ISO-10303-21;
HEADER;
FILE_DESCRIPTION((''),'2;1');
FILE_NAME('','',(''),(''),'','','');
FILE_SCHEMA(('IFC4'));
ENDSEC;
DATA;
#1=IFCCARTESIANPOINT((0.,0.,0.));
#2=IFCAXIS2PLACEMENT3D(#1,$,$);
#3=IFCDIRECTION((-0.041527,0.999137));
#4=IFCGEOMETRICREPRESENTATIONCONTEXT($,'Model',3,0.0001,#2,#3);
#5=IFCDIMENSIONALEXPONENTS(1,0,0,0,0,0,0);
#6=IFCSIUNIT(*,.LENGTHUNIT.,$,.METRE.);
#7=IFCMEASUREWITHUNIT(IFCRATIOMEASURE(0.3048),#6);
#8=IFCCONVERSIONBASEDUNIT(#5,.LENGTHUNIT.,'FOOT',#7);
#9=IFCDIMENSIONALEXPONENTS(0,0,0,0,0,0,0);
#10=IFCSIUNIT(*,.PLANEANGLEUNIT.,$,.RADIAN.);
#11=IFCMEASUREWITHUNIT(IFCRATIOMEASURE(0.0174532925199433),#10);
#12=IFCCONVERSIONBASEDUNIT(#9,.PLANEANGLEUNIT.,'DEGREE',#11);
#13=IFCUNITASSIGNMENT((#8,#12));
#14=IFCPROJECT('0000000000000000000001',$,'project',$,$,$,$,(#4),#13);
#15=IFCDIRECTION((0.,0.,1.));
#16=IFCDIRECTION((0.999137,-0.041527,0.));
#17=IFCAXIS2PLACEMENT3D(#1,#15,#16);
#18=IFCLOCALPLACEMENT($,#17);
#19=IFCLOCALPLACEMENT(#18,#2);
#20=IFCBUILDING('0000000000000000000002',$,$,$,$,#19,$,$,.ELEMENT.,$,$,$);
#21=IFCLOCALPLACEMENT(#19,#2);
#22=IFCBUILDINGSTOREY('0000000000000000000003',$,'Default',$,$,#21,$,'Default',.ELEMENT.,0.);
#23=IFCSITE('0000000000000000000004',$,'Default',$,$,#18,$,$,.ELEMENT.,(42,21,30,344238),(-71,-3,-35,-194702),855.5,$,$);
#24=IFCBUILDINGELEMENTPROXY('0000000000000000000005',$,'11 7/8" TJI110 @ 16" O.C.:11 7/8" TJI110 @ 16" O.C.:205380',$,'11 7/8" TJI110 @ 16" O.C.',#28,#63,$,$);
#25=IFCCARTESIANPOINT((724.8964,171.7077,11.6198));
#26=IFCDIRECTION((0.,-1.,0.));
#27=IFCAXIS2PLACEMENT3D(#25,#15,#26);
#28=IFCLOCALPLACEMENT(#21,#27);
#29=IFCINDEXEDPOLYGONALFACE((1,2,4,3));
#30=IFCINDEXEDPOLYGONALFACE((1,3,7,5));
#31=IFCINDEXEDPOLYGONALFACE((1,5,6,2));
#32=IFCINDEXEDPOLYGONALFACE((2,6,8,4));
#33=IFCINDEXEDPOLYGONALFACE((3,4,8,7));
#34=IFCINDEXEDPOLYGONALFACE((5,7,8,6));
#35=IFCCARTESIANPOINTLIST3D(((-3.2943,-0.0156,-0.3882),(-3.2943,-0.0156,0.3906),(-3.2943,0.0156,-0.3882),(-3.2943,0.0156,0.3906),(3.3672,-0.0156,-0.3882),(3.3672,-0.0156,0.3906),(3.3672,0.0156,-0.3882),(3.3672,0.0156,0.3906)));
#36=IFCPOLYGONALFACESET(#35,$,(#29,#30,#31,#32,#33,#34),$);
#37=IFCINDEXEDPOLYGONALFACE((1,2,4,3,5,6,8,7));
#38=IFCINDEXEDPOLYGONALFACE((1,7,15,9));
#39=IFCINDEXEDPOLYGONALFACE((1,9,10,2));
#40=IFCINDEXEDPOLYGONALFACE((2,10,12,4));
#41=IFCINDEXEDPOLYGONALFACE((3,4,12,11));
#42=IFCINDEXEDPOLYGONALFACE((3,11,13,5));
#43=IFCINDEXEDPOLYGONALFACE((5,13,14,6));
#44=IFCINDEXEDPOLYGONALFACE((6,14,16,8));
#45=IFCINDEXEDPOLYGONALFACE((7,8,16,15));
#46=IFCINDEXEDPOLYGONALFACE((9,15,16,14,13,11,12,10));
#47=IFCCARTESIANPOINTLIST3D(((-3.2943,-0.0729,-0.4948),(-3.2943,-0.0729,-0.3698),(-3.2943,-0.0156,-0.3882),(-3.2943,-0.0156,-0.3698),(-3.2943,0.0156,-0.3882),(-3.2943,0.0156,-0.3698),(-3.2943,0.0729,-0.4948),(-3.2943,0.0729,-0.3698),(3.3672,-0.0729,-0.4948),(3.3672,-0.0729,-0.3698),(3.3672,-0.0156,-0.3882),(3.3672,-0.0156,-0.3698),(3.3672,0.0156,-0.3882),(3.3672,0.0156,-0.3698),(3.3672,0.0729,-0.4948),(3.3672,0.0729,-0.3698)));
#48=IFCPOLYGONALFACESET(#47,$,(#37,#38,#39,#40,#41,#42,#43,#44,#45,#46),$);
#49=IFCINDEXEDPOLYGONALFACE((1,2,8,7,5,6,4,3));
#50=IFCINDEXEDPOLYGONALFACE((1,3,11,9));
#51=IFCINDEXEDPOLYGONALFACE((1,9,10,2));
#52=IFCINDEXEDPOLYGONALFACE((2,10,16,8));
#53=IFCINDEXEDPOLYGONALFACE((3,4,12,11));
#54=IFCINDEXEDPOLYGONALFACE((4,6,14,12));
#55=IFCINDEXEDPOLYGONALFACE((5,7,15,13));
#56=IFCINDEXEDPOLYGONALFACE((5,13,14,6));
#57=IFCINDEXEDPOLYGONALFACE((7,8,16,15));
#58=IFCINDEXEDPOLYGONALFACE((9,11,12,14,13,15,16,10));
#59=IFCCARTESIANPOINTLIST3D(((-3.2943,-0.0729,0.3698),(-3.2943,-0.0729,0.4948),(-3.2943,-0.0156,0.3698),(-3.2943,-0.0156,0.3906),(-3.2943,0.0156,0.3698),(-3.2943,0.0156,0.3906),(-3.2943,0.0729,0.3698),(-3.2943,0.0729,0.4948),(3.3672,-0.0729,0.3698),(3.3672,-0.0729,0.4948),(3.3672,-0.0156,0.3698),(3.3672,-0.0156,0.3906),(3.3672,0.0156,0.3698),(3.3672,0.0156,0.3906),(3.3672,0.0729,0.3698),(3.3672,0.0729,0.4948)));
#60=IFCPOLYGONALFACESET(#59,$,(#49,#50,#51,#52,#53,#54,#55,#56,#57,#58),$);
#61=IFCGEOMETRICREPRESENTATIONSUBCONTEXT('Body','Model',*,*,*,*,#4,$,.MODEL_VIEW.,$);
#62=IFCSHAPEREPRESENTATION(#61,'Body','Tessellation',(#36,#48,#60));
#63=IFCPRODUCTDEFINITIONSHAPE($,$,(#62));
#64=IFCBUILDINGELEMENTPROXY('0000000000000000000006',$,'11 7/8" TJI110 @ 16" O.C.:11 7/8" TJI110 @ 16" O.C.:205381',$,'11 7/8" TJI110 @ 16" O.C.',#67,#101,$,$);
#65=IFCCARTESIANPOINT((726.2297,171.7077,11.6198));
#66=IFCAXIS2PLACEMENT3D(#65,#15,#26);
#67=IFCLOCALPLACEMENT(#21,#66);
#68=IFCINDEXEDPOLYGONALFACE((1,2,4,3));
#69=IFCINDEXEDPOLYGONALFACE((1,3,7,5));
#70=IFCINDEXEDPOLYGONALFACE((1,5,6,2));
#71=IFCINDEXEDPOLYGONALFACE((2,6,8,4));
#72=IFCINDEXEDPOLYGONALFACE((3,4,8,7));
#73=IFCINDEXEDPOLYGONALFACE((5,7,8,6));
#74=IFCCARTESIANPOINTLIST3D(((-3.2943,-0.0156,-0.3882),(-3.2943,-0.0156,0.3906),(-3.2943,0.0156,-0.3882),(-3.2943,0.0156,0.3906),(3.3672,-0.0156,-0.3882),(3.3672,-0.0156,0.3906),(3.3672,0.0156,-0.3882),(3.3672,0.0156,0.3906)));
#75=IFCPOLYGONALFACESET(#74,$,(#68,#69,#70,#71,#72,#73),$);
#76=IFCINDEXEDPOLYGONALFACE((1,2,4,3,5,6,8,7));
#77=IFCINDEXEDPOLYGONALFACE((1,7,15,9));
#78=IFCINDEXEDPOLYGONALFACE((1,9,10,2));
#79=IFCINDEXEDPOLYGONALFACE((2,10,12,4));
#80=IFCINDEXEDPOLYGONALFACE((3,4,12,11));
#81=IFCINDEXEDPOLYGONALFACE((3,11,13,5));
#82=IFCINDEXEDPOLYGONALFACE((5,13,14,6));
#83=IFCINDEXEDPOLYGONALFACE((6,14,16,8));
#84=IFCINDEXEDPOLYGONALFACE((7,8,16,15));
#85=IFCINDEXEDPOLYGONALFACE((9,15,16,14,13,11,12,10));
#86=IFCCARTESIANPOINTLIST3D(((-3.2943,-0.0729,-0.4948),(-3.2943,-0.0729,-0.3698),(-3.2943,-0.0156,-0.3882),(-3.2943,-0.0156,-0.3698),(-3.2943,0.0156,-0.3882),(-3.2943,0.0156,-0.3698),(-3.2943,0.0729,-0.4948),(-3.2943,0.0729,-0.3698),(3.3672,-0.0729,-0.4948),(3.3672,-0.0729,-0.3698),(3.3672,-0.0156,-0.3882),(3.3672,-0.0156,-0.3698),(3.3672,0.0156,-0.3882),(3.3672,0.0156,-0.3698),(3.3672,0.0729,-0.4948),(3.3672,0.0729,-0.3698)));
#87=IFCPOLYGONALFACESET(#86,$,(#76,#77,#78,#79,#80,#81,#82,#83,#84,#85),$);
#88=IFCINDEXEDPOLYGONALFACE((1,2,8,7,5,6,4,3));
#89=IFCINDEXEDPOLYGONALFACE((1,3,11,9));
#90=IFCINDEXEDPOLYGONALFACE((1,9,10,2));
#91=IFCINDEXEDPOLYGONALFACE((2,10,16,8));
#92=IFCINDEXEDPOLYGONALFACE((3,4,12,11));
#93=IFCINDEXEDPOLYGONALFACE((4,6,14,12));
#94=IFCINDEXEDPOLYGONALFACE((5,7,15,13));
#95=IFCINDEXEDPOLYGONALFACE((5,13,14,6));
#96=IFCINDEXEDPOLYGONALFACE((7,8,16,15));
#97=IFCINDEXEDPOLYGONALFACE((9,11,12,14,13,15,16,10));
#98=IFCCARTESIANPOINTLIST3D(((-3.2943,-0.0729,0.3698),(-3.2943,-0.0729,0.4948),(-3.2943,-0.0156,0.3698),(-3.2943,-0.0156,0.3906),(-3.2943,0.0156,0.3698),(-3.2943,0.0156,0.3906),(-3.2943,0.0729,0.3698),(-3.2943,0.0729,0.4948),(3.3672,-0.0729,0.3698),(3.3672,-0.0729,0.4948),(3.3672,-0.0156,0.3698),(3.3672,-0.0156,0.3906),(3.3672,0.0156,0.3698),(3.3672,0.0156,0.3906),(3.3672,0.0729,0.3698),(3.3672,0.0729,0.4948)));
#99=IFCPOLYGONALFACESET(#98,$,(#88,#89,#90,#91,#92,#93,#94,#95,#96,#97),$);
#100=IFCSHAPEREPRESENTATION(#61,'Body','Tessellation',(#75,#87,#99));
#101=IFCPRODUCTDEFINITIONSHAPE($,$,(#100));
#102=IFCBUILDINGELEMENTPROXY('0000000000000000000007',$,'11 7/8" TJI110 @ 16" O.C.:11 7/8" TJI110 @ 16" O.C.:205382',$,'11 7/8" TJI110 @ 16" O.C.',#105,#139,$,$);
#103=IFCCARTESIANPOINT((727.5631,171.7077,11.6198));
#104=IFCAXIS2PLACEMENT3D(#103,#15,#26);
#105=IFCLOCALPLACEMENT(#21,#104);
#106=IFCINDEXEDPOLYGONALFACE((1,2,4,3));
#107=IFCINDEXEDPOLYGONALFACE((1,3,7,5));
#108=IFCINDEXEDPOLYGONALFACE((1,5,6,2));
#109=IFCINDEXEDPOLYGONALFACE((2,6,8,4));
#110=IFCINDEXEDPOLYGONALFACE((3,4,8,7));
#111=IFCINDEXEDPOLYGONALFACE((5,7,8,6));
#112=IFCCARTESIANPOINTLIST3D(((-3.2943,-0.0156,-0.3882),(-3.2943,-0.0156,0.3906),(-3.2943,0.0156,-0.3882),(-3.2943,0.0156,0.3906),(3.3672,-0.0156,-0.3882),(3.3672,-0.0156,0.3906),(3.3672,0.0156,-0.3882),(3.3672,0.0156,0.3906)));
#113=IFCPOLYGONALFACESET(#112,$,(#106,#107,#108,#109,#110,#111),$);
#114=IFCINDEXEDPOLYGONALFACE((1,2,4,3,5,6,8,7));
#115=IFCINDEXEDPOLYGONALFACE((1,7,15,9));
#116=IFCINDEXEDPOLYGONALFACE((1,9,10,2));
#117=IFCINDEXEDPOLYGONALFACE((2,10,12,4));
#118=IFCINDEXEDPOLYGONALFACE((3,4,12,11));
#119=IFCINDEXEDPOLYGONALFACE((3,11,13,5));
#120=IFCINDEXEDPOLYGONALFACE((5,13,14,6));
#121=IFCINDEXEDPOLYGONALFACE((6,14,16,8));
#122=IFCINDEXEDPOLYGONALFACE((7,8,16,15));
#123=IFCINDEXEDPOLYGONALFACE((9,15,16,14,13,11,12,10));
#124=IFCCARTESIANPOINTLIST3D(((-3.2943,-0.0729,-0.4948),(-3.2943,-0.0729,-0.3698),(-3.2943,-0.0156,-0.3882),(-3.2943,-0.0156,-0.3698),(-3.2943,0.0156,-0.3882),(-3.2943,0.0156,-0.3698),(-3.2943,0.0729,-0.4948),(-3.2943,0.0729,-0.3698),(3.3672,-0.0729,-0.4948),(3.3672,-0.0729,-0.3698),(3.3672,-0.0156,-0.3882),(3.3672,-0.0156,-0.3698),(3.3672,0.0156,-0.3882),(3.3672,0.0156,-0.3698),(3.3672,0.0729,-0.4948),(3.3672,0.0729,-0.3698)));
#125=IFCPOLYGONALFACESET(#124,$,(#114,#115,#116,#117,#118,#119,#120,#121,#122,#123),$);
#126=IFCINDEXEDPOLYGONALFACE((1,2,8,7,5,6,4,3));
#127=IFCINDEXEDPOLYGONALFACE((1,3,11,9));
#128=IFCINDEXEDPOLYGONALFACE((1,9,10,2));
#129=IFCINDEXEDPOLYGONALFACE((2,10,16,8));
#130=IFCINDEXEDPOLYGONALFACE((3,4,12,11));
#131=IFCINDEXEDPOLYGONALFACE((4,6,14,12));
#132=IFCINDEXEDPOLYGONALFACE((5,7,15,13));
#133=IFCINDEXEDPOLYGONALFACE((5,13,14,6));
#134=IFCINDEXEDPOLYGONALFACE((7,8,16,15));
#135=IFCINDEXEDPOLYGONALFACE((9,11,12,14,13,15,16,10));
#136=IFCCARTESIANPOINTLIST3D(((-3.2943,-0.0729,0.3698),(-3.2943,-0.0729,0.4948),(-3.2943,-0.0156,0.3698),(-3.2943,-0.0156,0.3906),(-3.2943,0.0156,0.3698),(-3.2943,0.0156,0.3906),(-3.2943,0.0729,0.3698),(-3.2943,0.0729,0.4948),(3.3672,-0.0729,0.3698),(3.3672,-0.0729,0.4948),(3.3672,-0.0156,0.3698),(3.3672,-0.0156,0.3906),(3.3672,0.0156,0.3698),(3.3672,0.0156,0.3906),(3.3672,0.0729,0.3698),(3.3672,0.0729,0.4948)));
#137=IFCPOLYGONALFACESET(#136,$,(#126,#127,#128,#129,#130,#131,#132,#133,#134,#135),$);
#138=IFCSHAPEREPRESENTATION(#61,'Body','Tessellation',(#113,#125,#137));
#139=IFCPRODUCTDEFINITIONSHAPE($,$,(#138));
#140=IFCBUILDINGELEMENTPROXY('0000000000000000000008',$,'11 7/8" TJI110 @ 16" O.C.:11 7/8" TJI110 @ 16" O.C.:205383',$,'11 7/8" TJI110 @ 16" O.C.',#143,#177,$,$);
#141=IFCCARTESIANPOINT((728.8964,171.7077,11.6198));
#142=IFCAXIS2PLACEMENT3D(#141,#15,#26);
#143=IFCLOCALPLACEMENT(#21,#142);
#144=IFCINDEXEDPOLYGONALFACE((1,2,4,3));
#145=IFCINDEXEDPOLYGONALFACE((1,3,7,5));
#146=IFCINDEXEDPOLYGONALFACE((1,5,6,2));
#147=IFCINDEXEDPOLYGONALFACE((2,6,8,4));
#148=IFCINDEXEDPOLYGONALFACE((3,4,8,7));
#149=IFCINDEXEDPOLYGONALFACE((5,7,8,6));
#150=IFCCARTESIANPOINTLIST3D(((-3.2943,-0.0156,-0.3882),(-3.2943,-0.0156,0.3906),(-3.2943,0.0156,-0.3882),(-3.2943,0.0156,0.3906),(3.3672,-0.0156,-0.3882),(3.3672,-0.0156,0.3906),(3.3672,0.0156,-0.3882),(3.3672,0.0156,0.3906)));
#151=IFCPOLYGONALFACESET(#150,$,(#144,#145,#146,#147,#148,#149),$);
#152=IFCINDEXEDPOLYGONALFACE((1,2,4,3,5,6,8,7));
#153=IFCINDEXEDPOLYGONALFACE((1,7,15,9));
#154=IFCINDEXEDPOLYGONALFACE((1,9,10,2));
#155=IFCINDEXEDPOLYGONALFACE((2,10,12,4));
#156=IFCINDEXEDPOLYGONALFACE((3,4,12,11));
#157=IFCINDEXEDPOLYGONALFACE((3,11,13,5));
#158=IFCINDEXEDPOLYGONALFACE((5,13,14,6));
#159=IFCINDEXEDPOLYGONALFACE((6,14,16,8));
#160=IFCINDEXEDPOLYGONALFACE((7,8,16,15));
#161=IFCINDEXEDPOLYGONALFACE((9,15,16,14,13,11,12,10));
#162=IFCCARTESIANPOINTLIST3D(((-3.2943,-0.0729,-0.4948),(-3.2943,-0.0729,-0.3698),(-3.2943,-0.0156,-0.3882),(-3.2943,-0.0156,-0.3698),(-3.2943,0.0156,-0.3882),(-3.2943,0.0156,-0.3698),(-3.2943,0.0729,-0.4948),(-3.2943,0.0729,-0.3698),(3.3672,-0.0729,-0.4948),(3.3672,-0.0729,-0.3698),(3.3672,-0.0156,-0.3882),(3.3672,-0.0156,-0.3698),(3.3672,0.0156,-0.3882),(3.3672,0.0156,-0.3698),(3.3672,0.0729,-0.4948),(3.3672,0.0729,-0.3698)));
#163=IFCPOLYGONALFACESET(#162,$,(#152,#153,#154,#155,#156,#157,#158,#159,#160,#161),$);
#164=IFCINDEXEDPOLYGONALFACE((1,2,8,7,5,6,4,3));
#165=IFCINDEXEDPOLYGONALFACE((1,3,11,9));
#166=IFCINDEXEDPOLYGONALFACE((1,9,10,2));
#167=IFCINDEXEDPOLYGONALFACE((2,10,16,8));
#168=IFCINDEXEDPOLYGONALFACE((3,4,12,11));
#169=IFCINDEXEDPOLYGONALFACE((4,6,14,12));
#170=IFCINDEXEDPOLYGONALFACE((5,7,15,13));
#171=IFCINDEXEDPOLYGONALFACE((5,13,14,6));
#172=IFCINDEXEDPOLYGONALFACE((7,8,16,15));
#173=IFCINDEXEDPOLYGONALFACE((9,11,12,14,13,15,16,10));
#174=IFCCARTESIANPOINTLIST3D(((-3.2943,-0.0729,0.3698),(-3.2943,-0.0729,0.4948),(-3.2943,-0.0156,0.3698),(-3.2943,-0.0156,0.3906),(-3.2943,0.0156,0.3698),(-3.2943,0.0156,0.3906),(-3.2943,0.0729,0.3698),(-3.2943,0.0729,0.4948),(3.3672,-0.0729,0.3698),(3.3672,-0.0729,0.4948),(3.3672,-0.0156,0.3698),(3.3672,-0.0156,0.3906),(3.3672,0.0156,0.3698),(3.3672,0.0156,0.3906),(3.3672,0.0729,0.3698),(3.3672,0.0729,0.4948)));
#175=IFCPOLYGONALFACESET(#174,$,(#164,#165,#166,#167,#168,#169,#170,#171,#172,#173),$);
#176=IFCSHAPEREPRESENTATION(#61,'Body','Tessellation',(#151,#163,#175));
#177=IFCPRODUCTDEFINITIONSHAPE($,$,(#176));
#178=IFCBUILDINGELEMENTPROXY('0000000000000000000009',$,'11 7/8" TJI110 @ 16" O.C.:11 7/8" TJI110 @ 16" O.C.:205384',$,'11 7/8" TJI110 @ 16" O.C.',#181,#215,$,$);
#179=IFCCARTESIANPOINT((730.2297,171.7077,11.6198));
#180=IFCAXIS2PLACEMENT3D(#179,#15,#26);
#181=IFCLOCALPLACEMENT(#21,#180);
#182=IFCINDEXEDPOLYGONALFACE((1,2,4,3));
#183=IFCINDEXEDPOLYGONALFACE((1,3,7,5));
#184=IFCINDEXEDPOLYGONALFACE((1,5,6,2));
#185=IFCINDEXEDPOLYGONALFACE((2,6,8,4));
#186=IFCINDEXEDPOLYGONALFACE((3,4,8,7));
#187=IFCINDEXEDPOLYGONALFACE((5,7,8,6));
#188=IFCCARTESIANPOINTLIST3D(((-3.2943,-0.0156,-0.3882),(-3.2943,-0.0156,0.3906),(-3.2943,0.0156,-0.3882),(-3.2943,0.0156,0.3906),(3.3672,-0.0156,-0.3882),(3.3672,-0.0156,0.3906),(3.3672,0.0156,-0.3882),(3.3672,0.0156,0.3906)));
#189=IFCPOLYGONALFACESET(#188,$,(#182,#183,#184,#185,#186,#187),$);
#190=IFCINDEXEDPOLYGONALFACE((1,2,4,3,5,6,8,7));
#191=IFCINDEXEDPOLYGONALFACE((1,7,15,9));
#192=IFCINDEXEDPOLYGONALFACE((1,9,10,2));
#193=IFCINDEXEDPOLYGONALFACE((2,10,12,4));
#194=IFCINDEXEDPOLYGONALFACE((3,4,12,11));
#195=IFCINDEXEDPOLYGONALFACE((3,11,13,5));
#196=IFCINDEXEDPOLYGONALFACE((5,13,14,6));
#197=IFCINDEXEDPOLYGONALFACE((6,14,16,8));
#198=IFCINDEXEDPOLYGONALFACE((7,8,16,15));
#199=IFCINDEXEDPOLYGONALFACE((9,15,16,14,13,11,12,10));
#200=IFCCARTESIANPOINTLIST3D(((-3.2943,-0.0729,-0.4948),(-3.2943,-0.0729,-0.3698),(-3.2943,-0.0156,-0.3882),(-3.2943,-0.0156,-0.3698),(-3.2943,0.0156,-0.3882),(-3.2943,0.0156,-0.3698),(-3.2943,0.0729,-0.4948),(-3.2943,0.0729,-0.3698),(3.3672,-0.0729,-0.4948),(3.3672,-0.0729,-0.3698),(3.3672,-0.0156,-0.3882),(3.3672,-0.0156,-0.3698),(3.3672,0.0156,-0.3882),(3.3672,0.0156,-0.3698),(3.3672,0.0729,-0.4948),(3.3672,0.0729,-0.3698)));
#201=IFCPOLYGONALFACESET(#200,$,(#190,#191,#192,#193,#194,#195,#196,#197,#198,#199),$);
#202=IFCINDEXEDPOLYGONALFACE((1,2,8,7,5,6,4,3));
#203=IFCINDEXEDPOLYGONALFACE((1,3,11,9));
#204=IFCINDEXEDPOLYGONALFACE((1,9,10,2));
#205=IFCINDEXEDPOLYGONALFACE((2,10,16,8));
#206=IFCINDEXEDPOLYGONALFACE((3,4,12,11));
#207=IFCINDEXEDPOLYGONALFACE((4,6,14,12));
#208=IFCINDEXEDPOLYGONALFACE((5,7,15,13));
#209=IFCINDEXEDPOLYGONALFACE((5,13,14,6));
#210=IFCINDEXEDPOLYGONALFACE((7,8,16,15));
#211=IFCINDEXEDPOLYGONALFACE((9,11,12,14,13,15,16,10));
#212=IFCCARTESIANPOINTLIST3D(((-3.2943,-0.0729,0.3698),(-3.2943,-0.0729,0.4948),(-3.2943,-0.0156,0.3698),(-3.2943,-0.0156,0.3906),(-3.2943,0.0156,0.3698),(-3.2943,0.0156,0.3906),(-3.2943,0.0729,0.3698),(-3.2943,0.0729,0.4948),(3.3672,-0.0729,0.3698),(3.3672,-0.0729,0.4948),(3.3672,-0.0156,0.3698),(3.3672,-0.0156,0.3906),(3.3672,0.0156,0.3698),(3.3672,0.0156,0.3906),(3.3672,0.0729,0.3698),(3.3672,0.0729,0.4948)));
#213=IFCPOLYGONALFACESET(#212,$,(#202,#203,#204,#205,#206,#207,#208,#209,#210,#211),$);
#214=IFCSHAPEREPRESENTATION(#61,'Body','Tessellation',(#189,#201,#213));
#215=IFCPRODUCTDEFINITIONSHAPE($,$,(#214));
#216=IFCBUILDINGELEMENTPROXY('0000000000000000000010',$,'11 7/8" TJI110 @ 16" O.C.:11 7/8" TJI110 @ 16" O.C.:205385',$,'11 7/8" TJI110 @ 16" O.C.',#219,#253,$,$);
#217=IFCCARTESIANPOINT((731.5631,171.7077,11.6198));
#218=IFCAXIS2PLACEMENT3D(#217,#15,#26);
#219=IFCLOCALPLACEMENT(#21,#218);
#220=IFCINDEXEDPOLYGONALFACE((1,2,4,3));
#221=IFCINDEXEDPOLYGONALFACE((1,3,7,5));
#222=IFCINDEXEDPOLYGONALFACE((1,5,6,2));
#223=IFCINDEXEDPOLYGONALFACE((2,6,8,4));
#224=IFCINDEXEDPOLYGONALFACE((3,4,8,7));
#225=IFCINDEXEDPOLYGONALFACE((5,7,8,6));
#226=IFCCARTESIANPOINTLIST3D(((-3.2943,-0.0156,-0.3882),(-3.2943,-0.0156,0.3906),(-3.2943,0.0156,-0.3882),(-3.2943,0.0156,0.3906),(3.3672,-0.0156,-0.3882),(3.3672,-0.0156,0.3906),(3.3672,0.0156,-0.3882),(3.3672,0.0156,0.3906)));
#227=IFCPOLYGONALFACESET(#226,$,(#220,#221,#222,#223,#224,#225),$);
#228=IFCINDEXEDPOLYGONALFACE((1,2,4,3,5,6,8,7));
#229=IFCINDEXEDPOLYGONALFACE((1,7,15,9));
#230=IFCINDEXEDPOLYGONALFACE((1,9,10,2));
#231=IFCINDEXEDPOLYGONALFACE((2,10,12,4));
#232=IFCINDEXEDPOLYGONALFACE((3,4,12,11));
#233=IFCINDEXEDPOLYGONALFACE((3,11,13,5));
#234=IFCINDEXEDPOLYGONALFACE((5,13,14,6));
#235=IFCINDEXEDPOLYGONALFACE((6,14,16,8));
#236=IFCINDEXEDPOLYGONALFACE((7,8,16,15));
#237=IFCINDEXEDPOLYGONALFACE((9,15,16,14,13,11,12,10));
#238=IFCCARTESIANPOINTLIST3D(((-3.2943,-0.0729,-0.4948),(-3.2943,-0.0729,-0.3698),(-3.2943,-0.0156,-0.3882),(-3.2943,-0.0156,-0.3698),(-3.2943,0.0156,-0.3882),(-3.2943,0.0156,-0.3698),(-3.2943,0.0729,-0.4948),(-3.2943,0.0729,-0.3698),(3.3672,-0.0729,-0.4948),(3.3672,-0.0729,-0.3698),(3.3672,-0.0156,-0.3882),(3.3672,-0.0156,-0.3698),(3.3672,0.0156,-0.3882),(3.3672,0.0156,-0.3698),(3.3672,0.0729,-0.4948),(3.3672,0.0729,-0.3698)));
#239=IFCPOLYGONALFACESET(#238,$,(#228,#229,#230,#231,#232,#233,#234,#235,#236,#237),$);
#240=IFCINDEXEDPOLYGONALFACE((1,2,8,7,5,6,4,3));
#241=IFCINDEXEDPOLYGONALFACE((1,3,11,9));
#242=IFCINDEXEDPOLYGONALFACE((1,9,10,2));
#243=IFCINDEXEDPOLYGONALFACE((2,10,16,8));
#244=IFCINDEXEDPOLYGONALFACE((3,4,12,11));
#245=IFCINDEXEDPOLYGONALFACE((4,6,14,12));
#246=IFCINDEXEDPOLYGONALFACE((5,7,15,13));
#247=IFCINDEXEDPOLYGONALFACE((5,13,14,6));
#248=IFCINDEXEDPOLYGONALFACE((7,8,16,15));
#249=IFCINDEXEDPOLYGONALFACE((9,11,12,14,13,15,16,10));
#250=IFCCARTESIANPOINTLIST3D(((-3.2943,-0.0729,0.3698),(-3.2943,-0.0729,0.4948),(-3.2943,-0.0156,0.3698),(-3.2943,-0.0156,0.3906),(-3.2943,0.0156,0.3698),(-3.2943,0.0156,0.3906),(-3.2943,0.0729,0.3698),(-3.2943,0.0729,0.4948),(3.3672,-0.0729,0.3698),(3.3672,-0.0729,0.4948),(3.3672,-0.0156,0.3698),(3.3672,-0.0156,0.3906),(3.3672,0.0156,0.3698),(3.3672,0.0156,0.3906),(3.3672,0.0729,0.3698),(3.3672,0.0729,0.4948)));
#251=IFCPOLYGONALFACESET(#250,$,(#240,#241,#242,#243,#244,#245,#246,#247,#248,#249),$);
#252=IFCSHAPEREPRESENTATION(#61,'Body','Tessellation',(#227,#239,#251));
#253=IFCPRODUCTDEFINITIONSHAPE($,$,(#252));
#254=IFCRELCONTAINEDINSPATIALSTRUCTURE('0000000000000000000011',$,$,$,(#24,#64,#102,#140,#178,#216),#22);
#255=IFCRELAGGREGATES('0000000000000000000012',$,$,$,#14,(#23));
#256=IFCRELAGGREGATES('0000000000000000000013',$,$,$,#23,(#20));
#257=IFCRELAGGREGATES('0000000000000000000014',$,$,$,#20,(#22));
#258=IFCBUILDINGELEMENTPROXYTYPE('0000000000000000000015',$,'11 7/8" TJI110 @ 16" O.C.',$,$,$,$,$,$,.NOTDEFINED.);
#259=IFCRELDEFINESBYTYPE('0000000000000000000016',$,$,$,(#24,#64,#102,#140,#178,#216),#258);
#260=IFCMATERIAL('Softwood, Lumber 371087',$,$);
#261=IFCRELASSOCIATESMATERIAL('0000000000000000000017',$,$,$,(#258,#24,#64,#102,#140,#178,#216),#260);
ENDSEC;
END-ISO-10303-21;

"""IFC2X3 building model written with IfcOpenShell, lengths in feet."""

from ifc_helpers import new_model, entity, si_unit, converted_unit, direction, frame, origin, origin_2d_with_axis, place, context, subcontext, project, spatial, polyline, rectangle, outline, extrude, source, transform, mapped, material, type_object, type_shapes, element, save


model = new_model("IFC2X3")

# Units and contexts
model_context = context("Model", 3, precision=0.0001, world=origin(), true_north=direction((-0.041527, 0.999137)))
body_context = subcontext(model_context, "Body", "Model", "MODEL_VIEW")
ifc_project = project(units=[converted_unit("LENGTHUNIT", "FOOT", entity("IfcRatioMeasure", 0.3048), si_unit("LENGTHUNIT", "METRE"), dimensions=[1, 0, 0, 0, 0, 0, 0]), converted_unit("PLANEANGLEUNIT", "DEGREE", entity("IfcRatioMeasure", 0.0174532925199433), si_unit("PLANEANGLEUNIT", "RADIAN"), dimensions=[0, 0, 0, 0, 0, 0, 0])], contexts=[model_context])

# Site, building, storey
site_placement = place(None, frame((0.0, 0.0, 0.0), z_axis=(0.0, 0.0, 1.0), x_axis=(0.999137, -0.041527, 0.0)))
site = spatial("IfcSite", under=ifc_project, at=site_placement, Name="Default", CompositionType="ELEMENT", RefLatitude=(42, 21, 30, 344238), RefLongitude=(-71, -3, -35, -194702), RefElevation=855.5)
building_placement = place(site_placement, origin())
building = spatial("IfcBuilding", under=site, at=building_placement, CompositionType="ELEMENT")
storey_placement = place(building_placement, origin())
storey = spatial("IfcBuildingStorey", under=building, at=storey_placement, Name="Default", LongName="Default", CompositionType="ELEMENT", Elevation=0.0)

# Building element proxies
ifc_material = material(Name="Softwood, Lumber 371087")
building_element_proxy_type_1 = type_object("IfcBuildingElementProxyType", Name="11 7/8\" TJI110 @ 16\" O.C.", PredefinedType="NOTDEFINED", material=ifc_material)
shared_shape_1 = source(origin(), body_context, "Body", "SweptSolid", [
    extrude(rectangle(XDim=6.6615, YDim=0.0313, at=origin_2d_with_axis()), frame((0.0365, 0.0, -0.3882), z_axis=(0.0, 0.0, 1.0), x_axis=(-1.0, 0.0, 0.0)), (0.0, 0.0, 1.0), 0.7788),
    extrude(outline(polyline([(-0.0891, -0.0729), (0.0359, -0.0729), (0.0359, -0.0156), (0.0174, -0.0156), (0.0174, 0.0156), (0.0359, 0.0156), (0.0359, 0.0729), (-0.0891, 0.0729), (-0.0891, -0.0729)])), frame((-3.2943, 0.0, -0.4056), z_axis=(1.0, 0.0, 0.0), x_axis=(0.0, 0.0, 1.0)), (0.0, 0.0, 1.0), 6.6615),
    extrude(outline(polyline([(-0.0729, -0.0885), (0.0729, -0.0885), (0.0729, 0.0365), (0.0156, 0.0365), (0.0156, 0.0156), (-0.0156, 0.0156), (-0.0156, 0.0365), (-0.0729, 0.0365), (-0.0729, -0.0885)])), frame((-3.2943, 0.0, 0.4062), z_axis=(1.0, 0.0, 0.0), x_axis=(0.0, -1.0, 0.0)), (0.0, 0.0, 1.0), 6.6615),
])
type_shapes(building_element_proxy_type_1, [shared_shape_1])
for number, where, z_axis, x_axis, name in (
    (1, (724.8964, 171.7077, 11.6198), (0.0, 0.0, 1.0), (0.0, -1.0, 0.0), "11 7/8\" TJI110 @ 16\" O.C.:11 7/8\" TJI110 @ 16\" O.C.:205380"),
    (2, (726.2297, 171.7077, 11.6198), (0.0, 0.0, 1.0), (0.0, -1.0, 0.0), "11 7/8\" TJI110 @ 16\" O.C.:11 7/8\" TJI110 @ 16\" O.C.:205381"),
    (3, (727.5631, 171.7077, 11.6198), (0.0, 0.0, 1.0), (0.0, -1.0, 0.0), "11 7/8\" TJI110 @ 16\" O.C.:11 7/8\" TJI110 @ 16\" O.C.:205382"),
    (4, (728.8964, 171.7077, 11.6198), (0.0, 0.0, 1.0), (0.0, -1.0, 0.0), "11 7/8\" TJI110 @ 16\" O.C.:11 7/8\" TJI110 @ 16\" O.C.:205383"),
    (5, (730.2297, 171.7077, 11.6198), (0.0, 0.0, 1.0), (0.0, -1.0, 0.0), "11 7/8\" TJI110 @ 16\" O.C.:11 7/8\" TJI110 @ 16\" O.C.:205384"),
    (6, (731.5631, 171.7077, 11.6198), (0.0, 0.0, 1.0), (0.0, -1.0, 0.0), "11 7/8\" TJI110 @ 16\" O.C.:11 7/8\" TJI110 @ 16\" O.C.:205385"),
):
    element("IfcBuildingElementProxy", number, at=place(storey_placement, frame(where, z_axis=z_axis, x_axis=x_axis)), inside=storey, type_object=building_element_proxy_type_1, material=ifc_material, Name=name, ObjectType="11 7/8\" TJI110 @ 16\" O.C.", context=body_context, shape_type="MappedRepresentation", body=[
        mapped(shared_shape_1, transform((0.0, 0.0, 0.0), scale=1.0)),
    ])

save(model, "model.ifc")
